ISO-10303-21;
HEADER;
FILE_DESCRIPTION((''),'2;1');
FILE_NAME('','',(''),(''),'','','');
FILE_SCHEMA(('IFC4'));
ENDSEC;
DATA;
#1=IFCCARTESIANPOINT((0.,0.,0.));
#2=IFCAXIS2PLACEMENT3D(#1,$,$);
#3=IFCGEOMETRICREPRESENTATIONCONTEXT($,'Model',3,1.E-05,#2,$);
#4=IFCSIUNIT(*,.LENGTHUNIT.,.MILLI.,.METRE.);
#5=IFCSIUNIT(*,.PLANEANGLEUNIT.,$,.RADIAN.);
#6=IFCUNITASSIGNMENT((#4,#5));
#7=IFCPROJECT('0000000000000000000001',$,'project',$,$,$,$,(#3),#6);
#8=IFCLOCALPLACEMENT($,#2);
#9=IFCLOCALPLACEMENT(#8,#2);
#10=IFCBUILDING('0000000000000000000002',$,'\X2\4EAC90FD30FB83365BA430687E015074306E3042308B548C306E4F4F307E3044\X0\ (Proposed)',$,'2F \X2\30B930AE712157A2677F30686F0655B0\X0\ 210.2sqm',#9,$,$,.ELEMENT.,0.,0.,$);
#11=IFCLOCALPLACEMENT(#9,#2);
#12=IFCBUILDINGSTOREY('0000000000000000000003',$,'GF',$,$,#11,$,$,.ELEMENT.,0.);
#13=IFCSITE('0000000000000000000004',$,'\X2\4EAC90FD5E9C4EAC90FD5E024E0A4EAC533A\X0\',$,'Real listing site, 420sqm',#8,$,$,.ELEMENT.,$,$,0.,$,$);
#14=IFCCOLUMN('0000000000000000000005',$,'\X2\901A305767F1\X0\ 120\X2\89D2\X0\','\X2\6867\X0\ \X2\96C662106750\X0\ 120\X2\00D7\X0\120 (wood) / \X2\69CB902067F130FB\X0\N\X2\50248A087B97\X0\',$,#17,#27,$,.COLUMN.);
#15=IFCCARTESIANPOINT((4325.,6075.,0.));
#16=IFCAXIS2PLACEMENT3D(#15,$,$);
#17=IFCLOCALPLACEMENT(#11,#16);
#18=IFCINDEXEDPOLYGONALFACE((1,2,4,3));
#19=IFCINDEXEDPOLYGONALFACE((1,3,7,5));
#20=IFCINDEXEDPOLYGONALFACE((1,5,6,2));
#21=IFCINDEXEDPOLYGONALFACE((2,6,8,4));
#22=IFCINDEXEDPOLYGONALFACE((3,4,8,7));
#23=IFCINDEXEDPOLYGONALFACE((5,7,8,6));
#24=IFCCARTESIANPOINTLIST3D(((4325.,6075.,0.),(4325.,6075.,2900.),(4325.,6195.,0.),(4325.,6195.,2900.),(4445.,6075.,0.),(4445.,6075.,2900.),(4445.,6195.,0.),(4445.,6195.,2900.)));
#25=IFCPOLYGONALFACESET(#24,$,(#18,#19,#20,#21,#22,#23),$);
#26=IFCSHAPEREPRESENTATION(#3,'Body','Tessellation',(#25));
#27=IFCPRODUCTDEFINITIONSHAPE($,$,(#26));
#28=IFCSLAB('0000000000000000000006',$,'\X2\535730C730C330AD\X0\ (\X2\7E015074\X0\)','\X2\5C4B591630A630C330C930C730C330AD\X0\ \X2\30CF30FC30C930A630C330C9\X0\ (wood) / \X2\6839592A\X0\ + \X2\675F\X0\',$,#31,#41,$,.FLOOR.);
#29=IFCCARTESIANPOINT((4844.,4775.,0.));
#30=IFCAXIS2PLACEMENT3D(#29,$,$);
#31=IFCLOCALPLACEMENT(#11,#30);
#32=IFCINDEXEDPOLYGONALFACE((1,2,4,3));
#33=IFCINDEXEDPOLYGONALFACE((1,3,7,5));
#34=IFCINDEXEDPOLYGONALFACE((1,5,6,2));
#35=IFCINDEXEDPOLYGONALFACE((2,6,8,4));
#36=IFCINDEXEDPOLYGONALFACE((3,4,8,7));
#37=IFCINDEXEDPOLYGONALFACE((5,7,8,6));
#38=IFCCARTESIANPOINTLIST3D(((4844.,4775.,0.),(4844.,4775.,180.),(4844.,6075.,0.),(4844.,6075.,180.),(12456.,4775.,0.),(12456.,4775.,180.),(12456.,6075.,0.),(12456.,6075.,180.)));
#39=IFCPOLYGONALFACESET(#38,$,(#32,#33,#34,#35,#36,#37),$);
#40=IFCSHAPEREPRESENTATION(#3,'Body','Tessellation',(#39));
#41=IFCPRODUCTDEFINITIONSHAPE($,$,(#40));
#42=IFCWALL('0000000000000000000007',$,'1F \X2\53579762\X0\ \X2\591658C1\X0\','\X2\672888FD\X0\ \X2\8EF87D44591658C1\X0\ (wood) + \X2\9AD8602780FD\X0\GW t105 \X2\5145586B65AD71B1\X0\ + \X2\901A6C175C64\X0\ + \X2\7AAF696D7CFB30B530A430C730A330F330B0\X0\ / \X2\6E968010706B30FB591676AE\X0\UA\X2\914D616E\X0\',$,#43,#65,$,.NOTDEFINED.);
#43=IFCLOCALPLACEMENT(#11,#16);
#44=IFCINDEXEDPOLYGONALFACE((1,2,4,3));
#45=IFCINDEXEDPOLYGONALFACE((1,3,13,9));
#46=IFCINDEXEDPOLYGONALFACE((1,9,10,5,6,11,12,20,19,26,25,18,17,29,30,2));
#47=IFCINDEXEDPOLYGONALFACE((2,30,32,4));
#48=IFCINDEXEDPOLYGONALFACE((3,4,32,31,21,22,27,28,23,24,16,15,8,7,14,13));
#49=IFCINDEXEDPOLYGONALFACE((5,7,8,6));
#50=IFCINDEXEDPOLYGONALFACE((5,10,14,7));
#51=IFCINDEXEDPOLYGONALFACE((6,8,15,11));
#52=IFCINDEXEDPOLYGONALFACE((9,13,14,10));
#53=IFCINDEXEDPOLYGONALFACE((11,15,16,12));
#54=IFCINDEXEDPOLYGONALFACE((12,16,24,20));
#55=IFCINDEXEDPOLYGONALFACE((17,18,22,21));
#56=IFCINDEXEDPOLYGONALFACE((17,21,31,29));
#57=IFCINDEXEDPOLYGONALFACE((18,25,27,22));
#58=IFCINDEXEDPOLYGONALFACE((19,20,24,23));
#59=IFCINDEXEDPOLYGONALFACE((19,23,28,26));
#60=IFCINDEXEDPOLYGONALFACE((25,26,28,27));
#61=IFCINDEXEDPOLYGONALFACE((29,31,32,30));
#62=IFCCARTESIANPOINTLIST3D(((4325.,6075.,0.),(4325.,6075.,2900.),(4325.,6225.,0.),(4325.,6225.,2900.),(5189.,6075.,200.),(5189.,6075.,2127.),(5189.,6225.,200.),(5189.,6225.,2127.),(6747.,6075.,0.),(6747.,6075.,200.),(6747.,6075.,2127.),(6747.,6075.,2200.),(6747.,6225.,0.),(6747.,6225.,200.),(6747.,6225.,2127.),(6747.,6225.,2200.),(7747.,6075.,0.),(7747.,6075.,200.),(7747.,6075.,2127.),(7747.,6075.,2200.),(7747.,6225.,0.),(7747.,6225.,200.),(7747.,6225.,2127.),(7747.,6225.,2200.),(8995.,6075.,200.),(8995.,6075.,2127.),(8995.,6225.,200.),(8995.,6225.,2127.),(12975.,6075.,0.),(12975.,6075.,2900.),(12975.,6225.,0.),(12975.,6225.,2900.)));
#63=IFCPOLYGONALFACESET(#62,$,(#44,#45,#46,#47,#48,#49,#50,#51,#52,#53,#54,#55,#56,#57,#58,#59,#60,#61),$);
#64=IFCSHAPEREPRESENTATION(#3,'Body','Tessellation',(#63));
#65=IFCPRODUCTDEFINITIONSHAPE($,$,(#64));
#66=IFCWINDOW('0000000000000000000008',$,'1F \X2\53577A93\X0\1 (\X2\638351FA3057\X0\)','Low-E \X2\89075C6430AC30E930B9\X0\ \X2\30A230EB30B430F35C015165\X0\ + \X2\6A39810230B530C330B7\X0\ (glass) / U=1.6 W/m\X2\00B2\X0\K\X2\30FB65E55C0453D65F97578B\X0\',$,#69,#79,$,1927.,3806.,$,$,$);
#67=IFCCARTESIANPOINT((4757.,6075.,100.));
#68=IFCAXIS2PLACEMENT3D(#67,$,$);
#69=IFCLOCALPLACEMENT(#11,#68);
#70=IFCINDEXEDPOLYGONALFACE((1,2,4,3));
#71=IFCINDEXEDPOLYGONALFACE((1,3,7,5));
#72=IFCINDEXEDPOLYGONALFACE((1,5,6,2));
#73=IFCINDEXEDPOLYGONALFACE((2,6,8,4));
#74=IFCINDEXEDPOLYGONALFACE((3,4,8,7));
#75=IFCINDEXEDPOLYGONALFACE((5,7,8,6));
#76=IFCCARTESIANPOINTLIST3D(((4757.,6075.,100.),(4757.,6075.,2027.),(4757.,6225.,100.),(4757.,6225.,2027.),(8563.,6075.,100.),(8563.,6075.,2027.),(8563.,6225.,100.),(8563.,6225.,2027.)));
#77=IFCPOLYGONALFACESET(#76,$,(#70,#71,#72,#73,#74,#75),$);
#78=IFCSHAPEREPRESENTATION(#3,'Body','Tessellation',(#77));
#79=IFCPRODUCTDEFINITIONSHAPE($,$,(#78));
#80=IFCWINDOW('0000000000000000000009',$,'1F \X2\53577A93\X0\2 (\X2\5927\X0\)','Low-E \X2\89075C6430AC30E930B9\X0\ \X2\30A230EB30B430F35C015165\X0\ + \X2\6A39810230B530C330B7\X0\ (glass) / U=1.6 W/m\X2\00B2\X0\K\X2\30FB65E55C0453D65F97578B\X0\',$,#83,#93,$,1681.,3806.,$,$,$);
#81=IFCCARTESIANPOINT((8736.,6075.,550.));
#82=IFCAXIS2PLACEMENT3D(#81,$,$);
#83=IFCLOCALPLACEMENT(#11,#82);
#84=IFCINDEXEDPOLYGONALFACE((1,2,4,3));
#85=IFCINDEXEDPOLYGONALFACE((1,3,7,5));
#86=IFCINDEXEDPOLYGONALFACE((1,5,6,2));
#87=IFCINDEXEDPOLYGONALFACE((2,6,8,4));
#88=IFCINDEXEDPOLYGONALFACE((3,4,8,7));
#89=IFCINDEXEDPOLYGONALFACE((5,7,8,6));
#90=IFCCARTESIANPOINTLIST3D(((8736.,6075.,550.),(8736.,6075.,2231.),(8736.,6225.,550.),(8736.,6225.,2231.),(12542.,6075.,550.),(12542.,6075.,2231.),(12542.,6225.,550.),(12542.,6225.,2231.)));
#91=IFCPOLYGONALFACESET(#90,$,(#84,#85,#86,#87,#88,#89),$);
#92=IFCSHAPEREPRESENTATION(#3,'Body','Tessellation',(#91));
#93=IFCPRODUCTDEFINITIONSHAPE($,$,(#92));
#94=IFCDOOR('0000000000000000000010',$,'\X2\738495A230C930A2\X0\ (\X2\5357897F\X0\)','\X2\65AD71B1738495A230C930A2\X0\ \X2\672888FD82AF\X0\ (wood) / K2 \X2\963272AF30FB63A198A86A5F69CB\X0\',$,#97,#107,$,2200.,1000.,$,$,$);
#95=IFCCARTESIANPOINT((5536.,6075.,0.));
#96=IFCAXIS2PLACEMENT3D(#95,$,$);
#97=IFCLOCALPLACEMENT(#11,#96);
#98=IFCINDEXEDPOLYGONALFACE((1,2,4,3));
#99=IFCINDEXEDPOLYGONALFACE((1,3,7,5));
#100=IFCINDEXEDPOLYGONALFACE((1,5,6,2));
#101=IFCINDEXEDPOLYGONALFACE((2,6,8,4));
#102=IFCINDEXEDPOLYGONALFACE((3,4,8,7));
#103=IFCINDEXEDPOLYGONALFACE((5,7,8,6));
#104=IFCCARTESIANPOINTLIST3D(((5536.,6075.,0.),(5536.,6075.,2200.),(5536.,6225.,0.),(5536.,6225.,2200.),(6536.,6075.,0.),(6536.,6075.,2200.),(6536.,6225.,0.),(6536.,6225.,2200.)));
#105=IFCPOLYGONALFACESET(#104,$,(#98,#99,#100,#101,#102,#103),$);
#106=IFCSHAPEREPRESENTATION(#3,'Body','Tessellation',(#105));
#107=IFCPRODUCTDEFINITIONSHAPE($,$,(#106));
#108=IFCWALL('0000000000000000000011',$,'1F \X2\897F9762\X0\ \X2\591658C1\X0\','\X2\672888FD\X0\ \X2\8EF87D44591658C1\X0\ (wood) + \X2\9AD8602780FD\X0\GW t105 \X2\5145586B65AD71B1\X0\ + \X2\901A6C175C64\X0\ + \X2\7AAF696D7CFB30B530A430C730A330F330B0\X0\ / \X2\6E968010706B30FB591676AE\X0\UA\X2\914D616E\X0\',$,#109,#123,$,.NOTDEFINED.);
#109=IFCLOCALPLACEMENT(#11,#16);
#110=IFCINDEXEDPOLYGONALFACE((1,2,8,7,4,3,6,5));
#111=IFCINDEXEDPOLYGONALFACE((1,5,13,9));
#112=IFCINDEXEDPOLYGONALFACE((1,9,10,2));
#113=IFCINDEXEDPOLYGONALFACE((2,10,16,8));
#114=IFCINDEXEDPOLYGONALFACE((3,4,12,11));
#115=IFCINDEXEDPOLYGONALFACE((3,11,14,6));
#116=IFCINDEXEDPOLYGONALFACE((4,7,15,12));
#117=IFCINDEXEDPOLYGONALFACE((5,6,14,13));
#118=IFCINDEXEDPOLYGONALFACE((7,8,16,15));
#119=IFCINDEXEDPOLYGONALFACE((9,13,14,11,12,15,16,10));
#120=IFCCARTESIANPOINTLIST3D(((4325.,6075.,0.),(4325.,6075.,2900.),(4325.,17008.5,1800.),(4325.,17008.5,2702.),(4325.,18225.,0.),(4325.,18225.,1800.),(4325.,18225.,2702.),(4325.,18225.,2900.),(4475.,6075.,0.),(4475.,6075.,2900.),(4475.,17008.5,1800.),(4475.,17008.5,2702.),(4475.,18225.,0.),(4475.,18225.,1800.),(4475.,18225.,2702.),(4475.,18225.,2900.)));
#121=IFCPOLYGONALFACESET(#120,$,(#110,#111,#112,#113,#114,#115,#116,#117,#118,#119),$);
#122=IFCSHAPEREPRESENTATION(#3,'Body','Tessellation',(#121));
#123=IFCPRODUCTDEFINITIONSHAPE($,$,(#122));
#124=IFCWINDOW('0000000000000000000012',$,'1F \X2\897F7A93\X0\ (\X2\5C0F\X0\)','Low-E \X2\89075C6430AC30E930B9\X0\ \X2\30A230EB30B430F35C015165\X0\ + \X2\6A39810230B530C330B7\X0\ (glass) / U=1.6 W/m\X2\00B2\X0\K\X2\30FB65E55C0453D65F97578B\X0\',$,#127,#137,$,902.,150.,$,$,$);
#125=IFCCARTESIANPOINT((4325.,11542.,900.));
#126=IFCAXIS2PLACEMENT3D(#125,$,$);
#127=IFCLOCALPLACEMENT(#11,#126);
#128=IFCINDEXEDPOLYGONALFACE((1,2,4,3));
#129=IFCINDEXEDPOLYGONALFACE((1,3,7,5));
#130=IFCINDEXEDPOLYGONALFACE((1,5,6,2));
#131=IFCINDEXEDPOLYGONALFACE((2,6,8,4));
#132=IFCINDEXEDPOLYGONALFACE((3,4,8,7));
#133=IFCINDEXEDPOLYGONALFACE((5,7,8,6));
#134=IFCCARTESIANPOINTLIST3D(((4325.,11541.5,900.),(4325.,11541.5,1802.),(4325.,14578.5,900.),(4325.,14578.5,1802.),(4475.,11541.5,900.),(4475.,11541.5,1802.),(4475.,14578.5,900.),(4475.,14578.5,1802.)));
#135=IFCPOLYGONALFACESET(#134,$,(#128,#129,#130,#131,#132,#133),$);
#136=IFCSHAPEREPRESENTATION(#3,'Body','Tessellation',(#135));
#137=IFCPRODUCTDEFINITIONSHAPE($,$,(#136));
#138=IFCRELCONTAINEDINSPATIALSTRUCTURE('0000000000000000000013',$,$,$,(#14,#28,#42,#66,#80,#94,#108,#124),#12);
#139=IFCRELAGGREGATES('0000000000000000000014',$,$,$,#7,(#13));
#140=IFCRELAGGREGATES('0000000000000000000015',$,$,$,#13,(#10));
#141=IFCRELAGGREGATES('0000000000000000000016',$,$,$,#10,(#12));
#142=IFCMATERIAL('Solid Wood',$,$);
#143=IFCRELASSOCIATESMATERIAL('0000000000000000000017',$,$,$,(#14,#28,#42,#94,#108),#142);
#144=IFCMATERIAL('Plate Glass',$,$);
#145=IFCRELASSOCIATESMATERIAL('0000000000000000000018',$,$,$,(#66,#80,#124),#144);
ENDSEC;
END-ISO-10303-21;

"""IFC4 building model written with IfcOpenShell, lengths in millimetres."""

from ifc_helpers import new_model, si_unit, frame, frame_2d, origin, place, context, project, spatial, rectangle, extrude, material, element, fill, save


model = new_model("IFC4")

# Units and contexts
model_context = context("Model", 3, precision=1e-05, world=origin())
ifc_project = project(units=[si_unit("LENGTHUNIT", "METRE", prefix="MILLI"), si_unit("PLANEANGLEUNIT", "RADIAN")], contexts=[model_context])

# Site, building, storey
site_placement = place(None, origin())
site = spatial("IfcSite", under=ifc_project, at=site_placement, Name="京都府京都市上京区", ObjectType="Real listing site, 420sqm", CompositionType="ELEMENT", RefElevation=0.0)
building_placement = place(site_placement, origin())
building = spatial("IfcBuilding", under=site, at=building_placement, Name="京都・茶室と縁側のある和の住まい (Proposed)", ObjectType="2F スギ無垢板と漆喰 210.2sqm", CompositionType="ELEMENT", ElevationOfRefHeight=0.0, ElevationOfTerrain=0.0)
storey_placement = place(building_placement, origin())
storey = spatial("IfcBuildingStorey", under=building, at=storey_placement, Name="GF", CompositionType="ELEMENT", Elevation=0.0)

# Column
ifc_material_1 = material(Name="Solid Wood")
column_placement = place(storey_placement, frame((4325.0, 6075.0, 0.0)))
element("IfcColumn", 1, at=column_placement, inside=storey, material=ifc_material_1, Name="通し柱 120角", Description="桧 集成材 120×120 (wood) / 構造柱・N値計算", PredefinedType="COLUMN", context=model_context, shape_type="SweptSolid", body=[
    extrude(rectangle(XDim=120.0, YDim=120.0, at=frame_2d((60.0, 60.0))), frame((4325.0, 6075.0, 0.0)), (0.0, 0.0, 1.0), 2900.0),
])

# Slab
slab_1_placement = place(storey_placement, frame((4844.0, 4775.0, 0.0)))
element("IfcSlab", 2, at=slab_1_placement, inside=storey, material=ifc_material_1, Name="南デッキ (縁側)", Description="屋外ウッドデッキ ハードウッド (wood) / 根太 + 束", PredefinedType="FLOOR", context=model_context, shape_type="SweptSolid", body=[
    extrude(rectangle(XDim=7612.0, YDim=1300.0, at=frame_2d((3806.0, 650.0))), frame((4844.0, 4775.0, 0.0)), (0.0, 0.0, 1.0), 180.0),
])

# Wall, openings, windows, door
wall_1_placement = place(storey_placement, frame((4325.0, 6075.0, 0.0)))
wall_1 = element("IfcWall", 3, at=wall_1_placement, inside=storey, material=ifc_material_1, Name="1F 南面 外壁", Description="木製 軸組外壁 (wood) + 高性能GW t105 充填断熱 + 通気層 + 窯業系サイディング / 準耐火・外皮UA配慮", PredefinedType="NOTDEFINED", context=model_context, shape_type="SweptSolid", body=[
    extrude(rectangle(XDim=8650.0, YDim=150.0, at=frame_2d((4325.0, 75.0))), frame((4325.0, 6075.0, 0.0)), (0.0, 0.0, 1.0), 2900.0),
])
opening_1_placement = place(storey_placement, frame((4757.0, 6075.0, 100.0)))
opening_1 = element("IfcOpeningElement", 4, at=opening_1_placement, cuts=wall_1, PredefinedType="NOTDEFINED", context=model_context, shape_type="SweptSolid", body=[
    extrude(rectangle(XDim=3806.0, YDim=150.0, at=frame_2d((1903.0, 75.0))), frame((4757.0, 6075.0, 100.0)), (0.0, 0.0, 1.0), 1927.0),
])
opening_2_placement = place(storey_placement, frame((8736.0, 6075.0, 550.0)))
opening_2 = element("IfcOpeningElement", 5, at=opening_2_placement, cuts=wall_1, PredefinedType="NOTDEFINED", context=model_context, shape_type="SweptSolid", body=[
    extrude(rectangle(XDim=3806.0, YDim=150.0, at=frame_2d((1903.0, 75.0))), frame((8736.0, 6075.0, 550.0)), (0.0, 0.0, 1.0), 1681.0),
])
opening_3_placement = place(storey_placement, frame((5536.0, 6075.0, 0.0)))
opening_3 = element("IfcOpeningElement", 6, at=opening_3_placement, cuts=wall_1, PredefinedType="NOTDEFINED", context=model_context, shape_type="SweptSolid", body=[
    extrude(rectangle(XDim=1000.0, YDim=150.0, at=frame_2d((500.0, 75.0))), frame((5536.0, 6075.0, 0.0)), (0.0, 0.0, 1.0), 2200.0),
])
ifc_material_2 = material(Name="Plate Glass")
window_1_placement = place(storey_placement, frame((4757.0, 6075.0, 100.0)))
window_1 = element("IfcWindow", 7, at=window_1_placement, inside=storey, material=ifc_material_2, Name="1F 南窓1 (掃出し)", Description="Low-E 複層ガラス アルゴン封入 + 樹脂サッシ (glass) / U=1.6 W/m²K・日射取得型", OverallHeight=1927.0, OverallWidth=3806.0, context=model_context, shape_type="SweptSolid", body=[
    extrude(rectangle(XDim=3806.0, YDim=150.0, at=frame_2d((1903.0, 75.0))), frame((4757.0, 6075.0, 100.0)), (0.0, 0.0, 1.0), 1927.0),
])
fill(opening_1, window_1)
window_2_placement = place(storey_placement, frame((8736.0, 6075.0, 550.0)))
window_2 = element("IfcWindow", 8, at=window_2_placement, inside=storey, material=ifc_material_2, Name="1F 南窓2 (大)", Description="Low-E 複層ガラス アルゴン封入 + 樹脂サッシ (glass) / U=1.6 W/m²K・日射取得型", OverallHeight=1681.0, OverallWidth=3806.0, context=model_context, shape_type="SweptSolid", body=[
    extrude(rectangle(XDim=3806.0, YDim=150.0, at=frame_2d((1903.0, 75.0))), frame((8736.0, 6075.0, 550.0)), (0.0, 0.0, 1.0), 1681.0),
])
fill(opening_2, window_2)
door_placement = place(storey_placement, frame((5536.0, 6075.0, 0.0)))
door = element("IfcDoor", 9, at=door_placement, inside=storey, material=ifc_material_1, Name="玄関ドア (南西)", Description="断熱玄関ドア 木製芯 (wood) / K2 防犯・採風機構", OverallHeight=2200.0, OverallWidth=1000.0, context=model_context, shape_type="SweptSolid", body=[
    extrude(rectangle(XDim=1000.0, YDim=150.0, at=frame_2d((500.0, 75.0))), frame((5536.0, 6075.0, 0.0)), (0.0, 0.0, 1.0), 2200.0),
])
fill(opening_3, door)

# Wall, opening, window
wall_2_placement = place(storey_placement, frame((4325.0, 6075.0, 0.0)))
wall_2 = element("IfcWall", 10, at=wall_2_placement, inside=storey, material=ifc_material_1, Name="1F 西面 外壁", Description="木製 軸組外壁 (wood) + 高性能GW t105 充填断熱 + 通気層 + 窯業系サイディング / 準耐火・外皮UA配慮", PredefinedType="NOTDEFINED", context=model_context, shape_type="SweptSolid", body=[
    extrude(rectangle(XDim=150.0, YDim=12150.0, at=frame_2d((75.0, 6075.0))), frame((4325.0, 6075.0, 0.0)), (0.0, 0.0, 1.0), 2900.0),
])
opening_4_placement = place(storey_placement, frame((4325.0, 11542.0, 900.0)))
opening_4 = element("IfcOpeningElement", 11, at=opening_4_placement, cuts=wall_2, PredefinedType="NOTDEFINED", context=model_context, shape_type="SweptSolid", body=[
    extrude(rectangle(XDim=150.0, YDim=3037.0, at=frame_2d((75.0, 1518.0))), frame((4325.0, 11542.0, 900.0)), (0.0, 0.0, 1.0), 902.0),
])
window_3_placement = place(storey_placement, frame((4325.0, 11542.0, 900.0)))
window_3 = element("IfcWindow", 12, at=window_3_placement, inside=storey, material=ifc_material_2, Name="1F 西窓 (小)", Description="Low-E 複層ガラス アルゴン封入 + 樹脂サッシ (glass) / U=1.6 W/m²K・日射取得型", OverallHeight=902.0, OverallWidth=150.0, context=model_context, shape_type="SweptSolid", body=[
    extrude(rectangle(XDim=150.0, YDim=3037.0, at=frame_2d((75.0, 1518.0))), frame((4325.0, 11542.0, 900.0)), (0.0, 0.0, 1.0), 902.0),
])
fill(opening_4, window_3)

save(model, "model.ifc")
